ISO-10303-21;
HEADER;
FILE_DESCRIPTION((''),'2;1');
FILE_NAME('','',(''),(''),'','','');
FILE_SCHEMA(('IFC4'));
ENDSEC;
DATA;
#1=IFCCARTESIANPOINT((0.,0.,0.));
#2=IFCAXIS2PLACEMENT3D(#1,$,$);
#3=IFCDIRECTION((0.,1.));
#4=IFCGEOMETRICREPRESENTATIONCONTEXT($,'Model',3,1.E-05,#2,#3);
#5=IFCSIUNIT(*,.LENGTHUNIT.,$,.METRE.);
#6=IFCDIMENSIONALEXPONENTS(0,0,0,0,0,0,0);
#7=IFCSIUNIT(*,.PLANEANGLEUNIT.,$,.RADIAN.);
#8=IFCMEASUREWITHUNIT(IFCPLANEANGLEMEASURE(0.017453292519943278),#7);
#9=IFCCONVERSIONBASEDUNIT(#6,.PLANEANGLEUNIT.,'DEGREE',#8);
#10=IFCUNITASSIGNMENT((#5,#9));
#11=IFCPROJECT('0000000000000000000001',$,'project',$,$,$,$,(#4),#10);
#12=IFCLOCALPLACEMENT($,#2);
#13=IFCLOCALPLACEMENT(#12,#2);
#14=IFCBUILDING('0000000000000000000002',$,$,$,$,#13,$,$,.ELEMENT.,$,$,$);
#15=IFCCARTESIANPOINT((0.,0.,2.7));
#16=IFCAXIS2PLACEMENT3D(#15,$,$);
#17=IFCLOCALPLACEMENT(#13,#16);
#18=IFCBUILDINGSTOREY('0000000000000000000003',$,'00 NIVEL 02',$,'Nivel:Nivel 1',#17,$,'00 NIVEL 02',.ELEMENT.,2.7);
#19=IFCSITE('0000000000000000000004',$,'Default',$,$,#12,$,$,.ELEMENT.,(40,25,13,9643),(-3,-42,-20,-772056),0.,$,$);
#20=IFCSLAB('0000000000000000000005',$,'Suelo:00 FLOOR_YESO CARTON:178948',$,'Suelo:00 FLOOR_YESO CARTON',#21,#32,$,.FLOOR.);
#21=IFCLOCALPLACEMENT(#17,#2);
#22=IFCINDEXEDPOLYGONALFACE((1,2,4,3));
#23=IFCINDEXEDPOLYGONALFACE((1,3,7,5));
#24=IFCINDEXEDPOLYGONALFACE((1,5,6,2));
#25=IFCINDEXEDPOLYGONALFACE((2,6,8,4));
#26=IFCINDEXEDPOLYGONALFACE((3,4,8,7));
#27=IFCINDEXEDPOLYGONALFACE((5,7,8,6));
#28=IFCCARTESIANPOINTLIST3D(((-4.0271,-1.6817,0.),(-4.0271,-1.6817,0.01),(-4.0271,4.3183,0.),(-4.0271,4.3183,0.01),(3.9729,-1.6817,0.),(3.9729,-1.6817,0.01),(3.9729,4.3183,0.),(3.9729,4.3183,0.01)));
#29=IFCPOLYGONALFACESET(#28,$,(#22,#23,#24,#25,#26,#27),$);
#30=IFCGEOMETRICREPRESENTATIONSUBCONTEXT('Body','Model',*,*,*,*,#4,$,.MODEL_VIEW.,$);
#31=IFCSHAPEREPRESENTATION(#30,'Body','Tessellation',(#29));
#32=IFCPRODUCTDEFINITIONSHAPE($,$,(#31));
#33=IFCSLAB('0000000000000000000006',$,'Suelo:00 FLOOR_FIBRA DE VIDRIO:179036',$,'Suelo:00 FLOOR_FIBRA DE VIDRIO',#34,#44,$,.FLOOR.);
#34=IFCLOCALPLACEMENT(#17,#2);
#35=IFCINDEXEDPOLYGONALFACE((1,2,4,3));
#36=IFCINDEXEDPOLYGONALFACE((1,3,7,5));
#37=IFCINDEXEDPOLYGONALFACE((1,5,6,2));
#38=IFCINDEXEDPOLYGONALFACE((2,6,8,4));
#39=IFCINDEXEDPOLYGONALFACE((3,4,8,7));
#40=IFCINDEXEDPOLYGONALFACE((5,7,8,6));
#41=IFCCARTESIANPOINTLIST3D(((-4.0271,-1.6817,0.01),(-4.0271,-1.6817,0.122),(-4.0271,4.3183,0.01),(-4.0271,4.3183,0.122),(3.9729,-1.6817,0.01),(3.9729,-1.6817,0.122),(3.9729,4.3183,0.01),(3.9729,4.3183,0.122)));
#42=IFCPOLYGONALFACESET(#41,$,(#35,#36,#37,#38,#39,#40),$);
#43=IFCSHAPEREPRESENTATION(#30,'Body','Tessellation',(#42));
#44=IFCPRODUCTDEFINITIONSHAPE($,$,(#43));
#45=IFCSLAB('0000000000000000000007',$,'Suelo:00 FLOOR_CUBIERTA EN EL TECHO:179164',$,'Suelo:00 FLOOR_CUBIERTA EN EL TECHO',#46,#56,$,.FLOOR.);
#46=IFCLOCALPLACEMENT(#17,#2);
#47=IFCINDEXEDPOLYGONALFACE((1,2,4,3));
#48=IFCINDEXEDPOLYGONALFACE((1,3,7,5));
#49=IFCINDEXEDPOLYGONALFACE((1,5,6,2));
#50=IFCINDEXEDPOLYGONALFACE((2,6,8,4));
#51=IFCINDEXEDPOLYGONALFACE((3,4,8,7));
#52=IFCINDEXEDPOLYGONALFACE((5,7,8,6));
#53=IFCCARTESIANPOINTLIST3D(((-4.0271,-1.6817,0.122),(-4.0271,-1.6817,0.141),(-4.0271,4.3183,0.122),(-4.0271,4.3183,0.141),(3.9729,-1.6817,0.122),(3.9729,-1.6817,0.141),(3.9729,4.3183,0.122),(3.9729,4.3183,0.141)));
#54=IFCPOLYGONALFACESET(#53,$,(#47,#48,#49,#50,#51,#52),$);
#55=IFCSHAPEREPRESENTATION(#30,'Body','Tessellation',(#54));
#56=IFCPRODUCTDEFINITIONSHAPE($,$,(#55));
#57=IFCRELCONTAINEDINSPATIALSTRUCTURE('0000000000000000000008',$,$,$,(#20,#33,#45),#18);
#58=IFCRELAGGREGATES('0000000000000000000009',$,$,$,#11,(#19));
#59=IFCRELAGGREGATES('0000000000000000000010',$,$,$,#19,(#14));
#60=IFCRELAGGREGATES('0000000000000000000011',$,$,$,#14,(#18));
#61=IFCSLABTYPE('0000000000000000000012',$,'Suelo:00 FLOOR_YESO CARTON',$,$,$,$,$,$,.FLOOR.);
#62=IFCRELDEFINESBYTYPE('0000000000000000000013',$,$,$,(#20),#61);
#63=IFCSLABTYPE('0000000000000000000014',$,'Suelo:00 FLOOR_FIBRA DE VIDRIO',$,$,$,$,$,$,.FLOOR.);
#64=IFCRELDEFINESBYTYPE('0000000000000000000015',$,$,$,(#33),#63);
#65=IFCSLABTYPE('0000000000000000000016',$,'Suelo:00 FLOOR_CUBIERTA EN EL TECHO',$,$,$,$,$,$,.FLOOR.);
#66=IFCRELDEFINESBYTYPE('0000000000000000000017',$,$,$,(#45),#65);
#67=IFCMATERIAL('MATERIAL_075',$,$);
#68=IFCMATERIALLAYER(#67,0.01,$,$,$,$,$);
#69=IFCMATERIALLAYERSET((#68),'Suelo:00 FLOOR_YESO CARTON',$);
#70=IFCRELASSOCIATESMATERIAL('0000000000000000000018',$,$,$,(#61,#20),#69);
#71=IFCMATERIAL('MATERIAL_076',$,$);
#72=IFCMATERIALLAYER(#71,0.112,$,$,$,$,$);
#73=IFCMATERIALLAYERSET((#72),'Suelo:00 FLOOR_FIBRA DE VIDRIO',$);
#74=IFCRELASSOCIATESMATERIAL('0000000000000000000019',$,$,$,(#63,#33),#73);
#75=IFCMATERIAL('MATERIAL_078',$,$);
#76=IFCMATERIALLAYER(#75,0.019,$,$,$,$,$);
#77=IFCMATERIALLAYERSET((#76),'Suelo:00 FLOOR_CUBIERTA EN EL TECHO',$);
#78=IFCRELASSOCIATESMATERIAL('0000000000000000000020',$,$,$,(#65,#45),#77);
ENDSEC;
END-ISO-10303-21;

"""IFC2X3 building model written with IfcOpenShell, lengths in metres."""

from ifc_helpers import new_model, entity, si_unit, converted_unit, direction, frame, origin, origin_2d_with_axis, place, context, subcontext, project, spatial, rectangle, extrude, material, layer, layer_set, layer_usage, type_object, element, save


model = new_model("IFC2X3")

# Units and contexts
model_context = context("Model", 3, precision=1e-05, world=origin(), true_north=direction((0.0, 1.0)))
body_context = subcontext(model_context, "Body", "Model", "MODEL_VIEW")
ifc_project = project(units=[si_unit("LENGTHUNIT", "METRE"), converted_unit("PLANEANGLEUNIT", "DEGREE", entity("IfcPlaneAngleMeasure", 0.017453292519943278), si_unit("PLANEANGLEUNIT", "RADIAN"), dimensions=[0, 0, 0, 0, 0, 0, 0])], contexts=[model_context])

# Site, building, storey
site_placement = place(None, origin())
site = spatial("IfcSite", under=ifc_project, at=site_placement, Name="Default", CompositionType="ELEMENT", RefLatitude=(40, 25, 13, 9643), RefLongitude=(-3, -42, -20, -772056), RefElevation=0.0)
building_placement = place(site_placement, origin())
building = spatial("IfcBuilding", under=site, at=building_placement, CompositionType="ELEMENT")
storey_placement = place(building_placement, frame((0.0, 0.0, 2.7)))
storey = spatial("IfcBuildingStorey", under=building, at=storey_placement, Name="00 NIVEL 02", ObjectType="Nivel:Nivel 1", LongName="00 NIVEL 02", CompositionType="ELEMENT", Elevation=2.7)

# Slabs
ifc_material_1 = material(Name="MATERIAL_075")
ifc_layer_1 = layer(ifc_material_1, 0.01)
ifc_layer_set_1 = layer_set([ifc_layer_1], Name="Suelo:00 FLOOR_YESO CARTON")
ifc_layer_usage_1 = layer_usage(ifc_layer_set_1, "AXIS3", "POSITIVE", 0.0)
slab_type_1 = type_object("IfcSlabType", Name="Suelo:00 FLOOR_YESO CARTON", PredefinedType="FLOOR", material=ifc_layer_set_1)
slab_1_placement = place(storey_placement, origin())
element("IfcSlab", 1, at=slab_1_placement, inside=storey, type_object=slab_type_1, material=ifc_layer_usage_1, Name="Suelo:00 FLOOR_YESO CARTON:178948", ObjectType="Suelo:00 FLOOR_YESO CARTON", PredefinedType="FLOOR", context=body_context, shape_type="SweptSolid", body=[
    extrude(rectangle(XDim=6.0, YDim=8.0, at=origin_2d_with_axis()), frame((-0.0271, 1.3183, 0.01), z_axis=(0.0, 0.0, -1.0), x_axis=(0.0, 1.0, 0.0)), (0.0, 0.0, 1.0), 0.01),
])
ifc_material_2 = material(Name="MATERIAL_076")
ifc_layer_2 = layer(ifc_material_2, 0.112)
ifc_layer_set_2 = layer_set([ifc_layer_2], Name="Suelo:00 FLOOR_FIBRA DE VIDRIO")
ifc_layer_usage_2 = layer_usage(ifc_layer_set_2, "AXIS3", "POSITIVE", 0.0)
slab_type_2 = type_object("IfcSlabType", Name="Suelo:00 FLOOR_FIBRA DE VIDRIO", PredefinedType="FLOOR", material=ifc_layer_set_2)
slab_2_placement = place(storey_placement, origin())
element("IfcSlab", 2, at=slab_2_placement, inside=storey, type_object=slab_type_2, material=ifc_layer_usage_2, Name="Suelo:00 FLOOR_FIBRA DE VIDRIO:179036", ObjectType="Suelo:00 FLOOR_FIBRA DE VIDRIO", PredefinedType="FLOOR", context=body_context, shape_type="SweptSolid", body=[
    extrude(rectangle(XDim=6.0, YDim=8.0, at=origin_2d_with_axis()), frame((-0.0271, 1.3183, 0.122), z_axis=(0.0, 0.0, -1.0), x_axis=(0.0, 1.0, 0.0)), (0.0, 0.0, 1.0), 0.112),
])
ifc_material_3 = material(Name="MATERIAL_078")
ifc_layer_3 = layer(ifc_material_3, 0.019)
ifc_layer_set_3 = layer_set([ifc_layer_3], Name="Suelo:00 FLOOR_CUBIERTA EN EL TECHO")
ifc_layer_usage_3 = layer_usage(ifc_layer_set_3, "AXIS3", "POSITIVE", 0.0)
slab_type_3 = type_object("IfcSlabType", Name="Suelo:00 FLOOR_CUBIERTA EN EL TECHO", PredefinedType="FLOOR", material=ifc_layer_set_3)
slab_3_placement = place(storey_placement, origin())
element("IfcSlab", 3, at=slab_3_placement, inside=storey, type_object=slab_type_3, material=ifc_layer_usage_3, Name="Suelo:00 FLOOR_CUBIERTA EN EL TECHO:179164", ObjectType="Suelo:00 FLOOR_CUBIERTA EN EL TECHO", PredefinedType="FLOOR", context=body_context, shape_type="SweptSolid", body=[
    extrude(rectangle(XDim=6.0, YDim=8.0, at=origin_2d_with_axis()), frame((-0.0271, 1.3183, 0.141), z_axis=(0.0, 0.0, -1.0), x_axis=(0.0, 1.0, 0.0)), (0.0, 0.0, 1.0), 0.019),
])

save(model, "model.ifc")
